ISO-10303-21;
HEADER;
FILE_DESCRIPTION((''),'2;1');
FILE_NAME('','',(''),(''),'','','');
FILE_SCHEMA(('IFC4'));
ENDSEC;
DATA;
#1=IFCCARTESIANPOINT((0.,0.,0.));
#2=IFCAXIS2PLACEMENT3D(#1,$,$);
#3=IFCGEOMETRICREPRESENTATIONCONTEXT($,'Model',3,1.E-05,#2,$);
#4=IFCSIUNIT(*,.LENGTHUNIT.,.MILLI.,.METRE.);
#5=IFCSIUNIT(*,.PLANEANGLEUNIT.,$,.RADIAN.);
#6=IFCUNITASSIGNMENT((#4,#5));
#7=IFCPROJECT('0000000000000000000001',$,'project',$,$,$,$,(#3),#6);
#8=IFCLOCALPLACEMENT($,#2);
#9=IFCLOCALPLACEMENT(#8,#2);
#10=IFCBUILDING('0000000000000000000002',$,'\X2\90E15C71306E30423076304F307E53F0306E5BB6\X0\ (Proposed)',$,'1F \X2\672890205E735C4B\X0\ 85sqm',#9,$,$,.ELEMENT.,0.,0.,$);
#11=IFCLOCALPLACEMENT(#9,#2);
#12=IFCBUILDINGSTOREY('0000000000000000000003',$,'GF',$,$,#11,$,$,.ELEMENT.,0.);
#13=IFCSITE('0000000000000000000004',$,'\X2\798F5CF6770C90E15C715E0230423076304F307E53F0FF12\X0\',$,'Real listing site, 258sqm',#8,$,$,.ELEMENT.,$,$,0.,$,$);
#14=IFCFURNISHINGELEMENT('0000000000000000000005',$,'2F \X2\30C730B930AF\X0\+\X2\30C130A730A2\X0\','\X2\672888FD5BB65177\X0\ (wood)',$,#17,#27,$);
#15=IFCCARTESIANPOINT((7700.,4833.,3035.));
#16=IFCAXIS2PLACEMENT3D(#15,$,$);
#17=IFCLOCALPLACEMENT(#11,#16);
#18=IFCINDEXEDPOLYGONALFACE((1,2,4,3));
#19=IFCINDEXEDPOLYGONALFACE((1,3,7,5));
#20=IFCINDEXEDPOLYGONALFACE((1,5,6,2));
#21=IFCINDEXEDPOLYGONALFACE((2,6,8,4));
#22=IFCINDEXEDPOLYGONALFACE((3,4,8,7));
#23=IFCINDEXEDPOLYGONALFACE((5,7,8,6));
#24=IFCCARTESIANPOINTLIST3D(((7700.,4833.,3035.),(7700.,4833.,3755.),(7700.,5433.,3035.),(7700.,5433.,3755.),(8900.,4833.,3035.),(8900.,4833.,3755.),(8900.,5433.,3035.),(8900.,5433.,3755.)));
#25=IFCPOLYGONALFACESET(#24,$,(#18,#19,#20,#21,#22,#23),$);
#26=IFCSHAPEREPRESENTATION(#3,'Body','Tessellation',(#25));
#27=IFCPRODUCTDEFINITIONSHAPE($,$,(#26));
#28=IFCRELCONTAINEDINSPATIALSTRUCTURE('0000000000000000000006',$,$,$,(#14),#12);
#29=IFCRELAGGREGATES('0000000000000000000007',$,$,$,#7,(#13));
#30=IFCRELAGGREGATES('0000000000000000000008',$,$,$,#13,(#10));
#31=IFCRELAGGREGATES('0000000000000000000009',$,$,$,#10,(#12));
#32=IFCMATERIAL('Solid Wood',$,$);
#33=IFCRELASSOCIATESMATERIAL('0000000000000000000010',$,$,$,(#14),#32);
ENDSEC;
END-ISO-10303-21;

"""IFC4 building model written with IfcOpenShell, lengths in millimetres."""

from ifc_helpers import new_model, si_unit, frame, frame_2d, origin, place, context, project, spatial, rectangle, extrude, material, element, save


model = new_model("IFC4")

# Units and contexts
model_context = context("Model", 3, precision=1e-05, world=origin())
ifc_project = project(units=[si_unit("LENGTHUNIT", "METRE", prefix="MILLI"), si_unit("PLANEANGLEUNIT", "RADIAN")], contexts=[model_context])

# Site, building, storey
site_placement = place(None, origin())
site = spatial("IfcSite", under=ifc_project, at=site_placement, Name="福島県郡山市あぶくま台２", ObjectType="Real listing site, 258sqm", CompositionType="ELEMENT", RefElevation=0.0)
building_placement = place(site_placement, origin())
building = spatial("IfcBuilding", under=site, at=building_placement, Name="郡山のあぶくま台の家 (Proposed)", ObjectType="1F 木造平屋 85sqm", CompositionType="ELEMENT", ElevationOfRefHeight=0.0, ElevationOfTerrain=0.0)
storey_placement = place(building_placement, origin())
storey = spatial("IfcBuildingStorey", under=building, at=storey_placement, Name="GF", CompositionType="ELEMENT", Elevation=0.0)

# Shared definitions
ifc_material_1 = material(Name="Solid Wood")

# Furnishing element
furnishing_1_placement = place(storey_placement, frame((7700.0, 4833.0, 3035.0)))
element("IfcFurnishingElement", 1, at=furnishing_1_placement, inside=storey, material=ifc_material_1, Name="2F デスク+チェア", Description="木製家具 (wood)", context=model_context, shape_type="SweptSolid", body=[
    extrude(rectangle(XDim=1200.0, YDim=600.0, at=frame_2d((600.0, 300.0))), frame((7700.0, 4833.0, 3035.0)), (0.0, 0.0, 1.0), 720.0),
])

save(model, "model.ifc")
